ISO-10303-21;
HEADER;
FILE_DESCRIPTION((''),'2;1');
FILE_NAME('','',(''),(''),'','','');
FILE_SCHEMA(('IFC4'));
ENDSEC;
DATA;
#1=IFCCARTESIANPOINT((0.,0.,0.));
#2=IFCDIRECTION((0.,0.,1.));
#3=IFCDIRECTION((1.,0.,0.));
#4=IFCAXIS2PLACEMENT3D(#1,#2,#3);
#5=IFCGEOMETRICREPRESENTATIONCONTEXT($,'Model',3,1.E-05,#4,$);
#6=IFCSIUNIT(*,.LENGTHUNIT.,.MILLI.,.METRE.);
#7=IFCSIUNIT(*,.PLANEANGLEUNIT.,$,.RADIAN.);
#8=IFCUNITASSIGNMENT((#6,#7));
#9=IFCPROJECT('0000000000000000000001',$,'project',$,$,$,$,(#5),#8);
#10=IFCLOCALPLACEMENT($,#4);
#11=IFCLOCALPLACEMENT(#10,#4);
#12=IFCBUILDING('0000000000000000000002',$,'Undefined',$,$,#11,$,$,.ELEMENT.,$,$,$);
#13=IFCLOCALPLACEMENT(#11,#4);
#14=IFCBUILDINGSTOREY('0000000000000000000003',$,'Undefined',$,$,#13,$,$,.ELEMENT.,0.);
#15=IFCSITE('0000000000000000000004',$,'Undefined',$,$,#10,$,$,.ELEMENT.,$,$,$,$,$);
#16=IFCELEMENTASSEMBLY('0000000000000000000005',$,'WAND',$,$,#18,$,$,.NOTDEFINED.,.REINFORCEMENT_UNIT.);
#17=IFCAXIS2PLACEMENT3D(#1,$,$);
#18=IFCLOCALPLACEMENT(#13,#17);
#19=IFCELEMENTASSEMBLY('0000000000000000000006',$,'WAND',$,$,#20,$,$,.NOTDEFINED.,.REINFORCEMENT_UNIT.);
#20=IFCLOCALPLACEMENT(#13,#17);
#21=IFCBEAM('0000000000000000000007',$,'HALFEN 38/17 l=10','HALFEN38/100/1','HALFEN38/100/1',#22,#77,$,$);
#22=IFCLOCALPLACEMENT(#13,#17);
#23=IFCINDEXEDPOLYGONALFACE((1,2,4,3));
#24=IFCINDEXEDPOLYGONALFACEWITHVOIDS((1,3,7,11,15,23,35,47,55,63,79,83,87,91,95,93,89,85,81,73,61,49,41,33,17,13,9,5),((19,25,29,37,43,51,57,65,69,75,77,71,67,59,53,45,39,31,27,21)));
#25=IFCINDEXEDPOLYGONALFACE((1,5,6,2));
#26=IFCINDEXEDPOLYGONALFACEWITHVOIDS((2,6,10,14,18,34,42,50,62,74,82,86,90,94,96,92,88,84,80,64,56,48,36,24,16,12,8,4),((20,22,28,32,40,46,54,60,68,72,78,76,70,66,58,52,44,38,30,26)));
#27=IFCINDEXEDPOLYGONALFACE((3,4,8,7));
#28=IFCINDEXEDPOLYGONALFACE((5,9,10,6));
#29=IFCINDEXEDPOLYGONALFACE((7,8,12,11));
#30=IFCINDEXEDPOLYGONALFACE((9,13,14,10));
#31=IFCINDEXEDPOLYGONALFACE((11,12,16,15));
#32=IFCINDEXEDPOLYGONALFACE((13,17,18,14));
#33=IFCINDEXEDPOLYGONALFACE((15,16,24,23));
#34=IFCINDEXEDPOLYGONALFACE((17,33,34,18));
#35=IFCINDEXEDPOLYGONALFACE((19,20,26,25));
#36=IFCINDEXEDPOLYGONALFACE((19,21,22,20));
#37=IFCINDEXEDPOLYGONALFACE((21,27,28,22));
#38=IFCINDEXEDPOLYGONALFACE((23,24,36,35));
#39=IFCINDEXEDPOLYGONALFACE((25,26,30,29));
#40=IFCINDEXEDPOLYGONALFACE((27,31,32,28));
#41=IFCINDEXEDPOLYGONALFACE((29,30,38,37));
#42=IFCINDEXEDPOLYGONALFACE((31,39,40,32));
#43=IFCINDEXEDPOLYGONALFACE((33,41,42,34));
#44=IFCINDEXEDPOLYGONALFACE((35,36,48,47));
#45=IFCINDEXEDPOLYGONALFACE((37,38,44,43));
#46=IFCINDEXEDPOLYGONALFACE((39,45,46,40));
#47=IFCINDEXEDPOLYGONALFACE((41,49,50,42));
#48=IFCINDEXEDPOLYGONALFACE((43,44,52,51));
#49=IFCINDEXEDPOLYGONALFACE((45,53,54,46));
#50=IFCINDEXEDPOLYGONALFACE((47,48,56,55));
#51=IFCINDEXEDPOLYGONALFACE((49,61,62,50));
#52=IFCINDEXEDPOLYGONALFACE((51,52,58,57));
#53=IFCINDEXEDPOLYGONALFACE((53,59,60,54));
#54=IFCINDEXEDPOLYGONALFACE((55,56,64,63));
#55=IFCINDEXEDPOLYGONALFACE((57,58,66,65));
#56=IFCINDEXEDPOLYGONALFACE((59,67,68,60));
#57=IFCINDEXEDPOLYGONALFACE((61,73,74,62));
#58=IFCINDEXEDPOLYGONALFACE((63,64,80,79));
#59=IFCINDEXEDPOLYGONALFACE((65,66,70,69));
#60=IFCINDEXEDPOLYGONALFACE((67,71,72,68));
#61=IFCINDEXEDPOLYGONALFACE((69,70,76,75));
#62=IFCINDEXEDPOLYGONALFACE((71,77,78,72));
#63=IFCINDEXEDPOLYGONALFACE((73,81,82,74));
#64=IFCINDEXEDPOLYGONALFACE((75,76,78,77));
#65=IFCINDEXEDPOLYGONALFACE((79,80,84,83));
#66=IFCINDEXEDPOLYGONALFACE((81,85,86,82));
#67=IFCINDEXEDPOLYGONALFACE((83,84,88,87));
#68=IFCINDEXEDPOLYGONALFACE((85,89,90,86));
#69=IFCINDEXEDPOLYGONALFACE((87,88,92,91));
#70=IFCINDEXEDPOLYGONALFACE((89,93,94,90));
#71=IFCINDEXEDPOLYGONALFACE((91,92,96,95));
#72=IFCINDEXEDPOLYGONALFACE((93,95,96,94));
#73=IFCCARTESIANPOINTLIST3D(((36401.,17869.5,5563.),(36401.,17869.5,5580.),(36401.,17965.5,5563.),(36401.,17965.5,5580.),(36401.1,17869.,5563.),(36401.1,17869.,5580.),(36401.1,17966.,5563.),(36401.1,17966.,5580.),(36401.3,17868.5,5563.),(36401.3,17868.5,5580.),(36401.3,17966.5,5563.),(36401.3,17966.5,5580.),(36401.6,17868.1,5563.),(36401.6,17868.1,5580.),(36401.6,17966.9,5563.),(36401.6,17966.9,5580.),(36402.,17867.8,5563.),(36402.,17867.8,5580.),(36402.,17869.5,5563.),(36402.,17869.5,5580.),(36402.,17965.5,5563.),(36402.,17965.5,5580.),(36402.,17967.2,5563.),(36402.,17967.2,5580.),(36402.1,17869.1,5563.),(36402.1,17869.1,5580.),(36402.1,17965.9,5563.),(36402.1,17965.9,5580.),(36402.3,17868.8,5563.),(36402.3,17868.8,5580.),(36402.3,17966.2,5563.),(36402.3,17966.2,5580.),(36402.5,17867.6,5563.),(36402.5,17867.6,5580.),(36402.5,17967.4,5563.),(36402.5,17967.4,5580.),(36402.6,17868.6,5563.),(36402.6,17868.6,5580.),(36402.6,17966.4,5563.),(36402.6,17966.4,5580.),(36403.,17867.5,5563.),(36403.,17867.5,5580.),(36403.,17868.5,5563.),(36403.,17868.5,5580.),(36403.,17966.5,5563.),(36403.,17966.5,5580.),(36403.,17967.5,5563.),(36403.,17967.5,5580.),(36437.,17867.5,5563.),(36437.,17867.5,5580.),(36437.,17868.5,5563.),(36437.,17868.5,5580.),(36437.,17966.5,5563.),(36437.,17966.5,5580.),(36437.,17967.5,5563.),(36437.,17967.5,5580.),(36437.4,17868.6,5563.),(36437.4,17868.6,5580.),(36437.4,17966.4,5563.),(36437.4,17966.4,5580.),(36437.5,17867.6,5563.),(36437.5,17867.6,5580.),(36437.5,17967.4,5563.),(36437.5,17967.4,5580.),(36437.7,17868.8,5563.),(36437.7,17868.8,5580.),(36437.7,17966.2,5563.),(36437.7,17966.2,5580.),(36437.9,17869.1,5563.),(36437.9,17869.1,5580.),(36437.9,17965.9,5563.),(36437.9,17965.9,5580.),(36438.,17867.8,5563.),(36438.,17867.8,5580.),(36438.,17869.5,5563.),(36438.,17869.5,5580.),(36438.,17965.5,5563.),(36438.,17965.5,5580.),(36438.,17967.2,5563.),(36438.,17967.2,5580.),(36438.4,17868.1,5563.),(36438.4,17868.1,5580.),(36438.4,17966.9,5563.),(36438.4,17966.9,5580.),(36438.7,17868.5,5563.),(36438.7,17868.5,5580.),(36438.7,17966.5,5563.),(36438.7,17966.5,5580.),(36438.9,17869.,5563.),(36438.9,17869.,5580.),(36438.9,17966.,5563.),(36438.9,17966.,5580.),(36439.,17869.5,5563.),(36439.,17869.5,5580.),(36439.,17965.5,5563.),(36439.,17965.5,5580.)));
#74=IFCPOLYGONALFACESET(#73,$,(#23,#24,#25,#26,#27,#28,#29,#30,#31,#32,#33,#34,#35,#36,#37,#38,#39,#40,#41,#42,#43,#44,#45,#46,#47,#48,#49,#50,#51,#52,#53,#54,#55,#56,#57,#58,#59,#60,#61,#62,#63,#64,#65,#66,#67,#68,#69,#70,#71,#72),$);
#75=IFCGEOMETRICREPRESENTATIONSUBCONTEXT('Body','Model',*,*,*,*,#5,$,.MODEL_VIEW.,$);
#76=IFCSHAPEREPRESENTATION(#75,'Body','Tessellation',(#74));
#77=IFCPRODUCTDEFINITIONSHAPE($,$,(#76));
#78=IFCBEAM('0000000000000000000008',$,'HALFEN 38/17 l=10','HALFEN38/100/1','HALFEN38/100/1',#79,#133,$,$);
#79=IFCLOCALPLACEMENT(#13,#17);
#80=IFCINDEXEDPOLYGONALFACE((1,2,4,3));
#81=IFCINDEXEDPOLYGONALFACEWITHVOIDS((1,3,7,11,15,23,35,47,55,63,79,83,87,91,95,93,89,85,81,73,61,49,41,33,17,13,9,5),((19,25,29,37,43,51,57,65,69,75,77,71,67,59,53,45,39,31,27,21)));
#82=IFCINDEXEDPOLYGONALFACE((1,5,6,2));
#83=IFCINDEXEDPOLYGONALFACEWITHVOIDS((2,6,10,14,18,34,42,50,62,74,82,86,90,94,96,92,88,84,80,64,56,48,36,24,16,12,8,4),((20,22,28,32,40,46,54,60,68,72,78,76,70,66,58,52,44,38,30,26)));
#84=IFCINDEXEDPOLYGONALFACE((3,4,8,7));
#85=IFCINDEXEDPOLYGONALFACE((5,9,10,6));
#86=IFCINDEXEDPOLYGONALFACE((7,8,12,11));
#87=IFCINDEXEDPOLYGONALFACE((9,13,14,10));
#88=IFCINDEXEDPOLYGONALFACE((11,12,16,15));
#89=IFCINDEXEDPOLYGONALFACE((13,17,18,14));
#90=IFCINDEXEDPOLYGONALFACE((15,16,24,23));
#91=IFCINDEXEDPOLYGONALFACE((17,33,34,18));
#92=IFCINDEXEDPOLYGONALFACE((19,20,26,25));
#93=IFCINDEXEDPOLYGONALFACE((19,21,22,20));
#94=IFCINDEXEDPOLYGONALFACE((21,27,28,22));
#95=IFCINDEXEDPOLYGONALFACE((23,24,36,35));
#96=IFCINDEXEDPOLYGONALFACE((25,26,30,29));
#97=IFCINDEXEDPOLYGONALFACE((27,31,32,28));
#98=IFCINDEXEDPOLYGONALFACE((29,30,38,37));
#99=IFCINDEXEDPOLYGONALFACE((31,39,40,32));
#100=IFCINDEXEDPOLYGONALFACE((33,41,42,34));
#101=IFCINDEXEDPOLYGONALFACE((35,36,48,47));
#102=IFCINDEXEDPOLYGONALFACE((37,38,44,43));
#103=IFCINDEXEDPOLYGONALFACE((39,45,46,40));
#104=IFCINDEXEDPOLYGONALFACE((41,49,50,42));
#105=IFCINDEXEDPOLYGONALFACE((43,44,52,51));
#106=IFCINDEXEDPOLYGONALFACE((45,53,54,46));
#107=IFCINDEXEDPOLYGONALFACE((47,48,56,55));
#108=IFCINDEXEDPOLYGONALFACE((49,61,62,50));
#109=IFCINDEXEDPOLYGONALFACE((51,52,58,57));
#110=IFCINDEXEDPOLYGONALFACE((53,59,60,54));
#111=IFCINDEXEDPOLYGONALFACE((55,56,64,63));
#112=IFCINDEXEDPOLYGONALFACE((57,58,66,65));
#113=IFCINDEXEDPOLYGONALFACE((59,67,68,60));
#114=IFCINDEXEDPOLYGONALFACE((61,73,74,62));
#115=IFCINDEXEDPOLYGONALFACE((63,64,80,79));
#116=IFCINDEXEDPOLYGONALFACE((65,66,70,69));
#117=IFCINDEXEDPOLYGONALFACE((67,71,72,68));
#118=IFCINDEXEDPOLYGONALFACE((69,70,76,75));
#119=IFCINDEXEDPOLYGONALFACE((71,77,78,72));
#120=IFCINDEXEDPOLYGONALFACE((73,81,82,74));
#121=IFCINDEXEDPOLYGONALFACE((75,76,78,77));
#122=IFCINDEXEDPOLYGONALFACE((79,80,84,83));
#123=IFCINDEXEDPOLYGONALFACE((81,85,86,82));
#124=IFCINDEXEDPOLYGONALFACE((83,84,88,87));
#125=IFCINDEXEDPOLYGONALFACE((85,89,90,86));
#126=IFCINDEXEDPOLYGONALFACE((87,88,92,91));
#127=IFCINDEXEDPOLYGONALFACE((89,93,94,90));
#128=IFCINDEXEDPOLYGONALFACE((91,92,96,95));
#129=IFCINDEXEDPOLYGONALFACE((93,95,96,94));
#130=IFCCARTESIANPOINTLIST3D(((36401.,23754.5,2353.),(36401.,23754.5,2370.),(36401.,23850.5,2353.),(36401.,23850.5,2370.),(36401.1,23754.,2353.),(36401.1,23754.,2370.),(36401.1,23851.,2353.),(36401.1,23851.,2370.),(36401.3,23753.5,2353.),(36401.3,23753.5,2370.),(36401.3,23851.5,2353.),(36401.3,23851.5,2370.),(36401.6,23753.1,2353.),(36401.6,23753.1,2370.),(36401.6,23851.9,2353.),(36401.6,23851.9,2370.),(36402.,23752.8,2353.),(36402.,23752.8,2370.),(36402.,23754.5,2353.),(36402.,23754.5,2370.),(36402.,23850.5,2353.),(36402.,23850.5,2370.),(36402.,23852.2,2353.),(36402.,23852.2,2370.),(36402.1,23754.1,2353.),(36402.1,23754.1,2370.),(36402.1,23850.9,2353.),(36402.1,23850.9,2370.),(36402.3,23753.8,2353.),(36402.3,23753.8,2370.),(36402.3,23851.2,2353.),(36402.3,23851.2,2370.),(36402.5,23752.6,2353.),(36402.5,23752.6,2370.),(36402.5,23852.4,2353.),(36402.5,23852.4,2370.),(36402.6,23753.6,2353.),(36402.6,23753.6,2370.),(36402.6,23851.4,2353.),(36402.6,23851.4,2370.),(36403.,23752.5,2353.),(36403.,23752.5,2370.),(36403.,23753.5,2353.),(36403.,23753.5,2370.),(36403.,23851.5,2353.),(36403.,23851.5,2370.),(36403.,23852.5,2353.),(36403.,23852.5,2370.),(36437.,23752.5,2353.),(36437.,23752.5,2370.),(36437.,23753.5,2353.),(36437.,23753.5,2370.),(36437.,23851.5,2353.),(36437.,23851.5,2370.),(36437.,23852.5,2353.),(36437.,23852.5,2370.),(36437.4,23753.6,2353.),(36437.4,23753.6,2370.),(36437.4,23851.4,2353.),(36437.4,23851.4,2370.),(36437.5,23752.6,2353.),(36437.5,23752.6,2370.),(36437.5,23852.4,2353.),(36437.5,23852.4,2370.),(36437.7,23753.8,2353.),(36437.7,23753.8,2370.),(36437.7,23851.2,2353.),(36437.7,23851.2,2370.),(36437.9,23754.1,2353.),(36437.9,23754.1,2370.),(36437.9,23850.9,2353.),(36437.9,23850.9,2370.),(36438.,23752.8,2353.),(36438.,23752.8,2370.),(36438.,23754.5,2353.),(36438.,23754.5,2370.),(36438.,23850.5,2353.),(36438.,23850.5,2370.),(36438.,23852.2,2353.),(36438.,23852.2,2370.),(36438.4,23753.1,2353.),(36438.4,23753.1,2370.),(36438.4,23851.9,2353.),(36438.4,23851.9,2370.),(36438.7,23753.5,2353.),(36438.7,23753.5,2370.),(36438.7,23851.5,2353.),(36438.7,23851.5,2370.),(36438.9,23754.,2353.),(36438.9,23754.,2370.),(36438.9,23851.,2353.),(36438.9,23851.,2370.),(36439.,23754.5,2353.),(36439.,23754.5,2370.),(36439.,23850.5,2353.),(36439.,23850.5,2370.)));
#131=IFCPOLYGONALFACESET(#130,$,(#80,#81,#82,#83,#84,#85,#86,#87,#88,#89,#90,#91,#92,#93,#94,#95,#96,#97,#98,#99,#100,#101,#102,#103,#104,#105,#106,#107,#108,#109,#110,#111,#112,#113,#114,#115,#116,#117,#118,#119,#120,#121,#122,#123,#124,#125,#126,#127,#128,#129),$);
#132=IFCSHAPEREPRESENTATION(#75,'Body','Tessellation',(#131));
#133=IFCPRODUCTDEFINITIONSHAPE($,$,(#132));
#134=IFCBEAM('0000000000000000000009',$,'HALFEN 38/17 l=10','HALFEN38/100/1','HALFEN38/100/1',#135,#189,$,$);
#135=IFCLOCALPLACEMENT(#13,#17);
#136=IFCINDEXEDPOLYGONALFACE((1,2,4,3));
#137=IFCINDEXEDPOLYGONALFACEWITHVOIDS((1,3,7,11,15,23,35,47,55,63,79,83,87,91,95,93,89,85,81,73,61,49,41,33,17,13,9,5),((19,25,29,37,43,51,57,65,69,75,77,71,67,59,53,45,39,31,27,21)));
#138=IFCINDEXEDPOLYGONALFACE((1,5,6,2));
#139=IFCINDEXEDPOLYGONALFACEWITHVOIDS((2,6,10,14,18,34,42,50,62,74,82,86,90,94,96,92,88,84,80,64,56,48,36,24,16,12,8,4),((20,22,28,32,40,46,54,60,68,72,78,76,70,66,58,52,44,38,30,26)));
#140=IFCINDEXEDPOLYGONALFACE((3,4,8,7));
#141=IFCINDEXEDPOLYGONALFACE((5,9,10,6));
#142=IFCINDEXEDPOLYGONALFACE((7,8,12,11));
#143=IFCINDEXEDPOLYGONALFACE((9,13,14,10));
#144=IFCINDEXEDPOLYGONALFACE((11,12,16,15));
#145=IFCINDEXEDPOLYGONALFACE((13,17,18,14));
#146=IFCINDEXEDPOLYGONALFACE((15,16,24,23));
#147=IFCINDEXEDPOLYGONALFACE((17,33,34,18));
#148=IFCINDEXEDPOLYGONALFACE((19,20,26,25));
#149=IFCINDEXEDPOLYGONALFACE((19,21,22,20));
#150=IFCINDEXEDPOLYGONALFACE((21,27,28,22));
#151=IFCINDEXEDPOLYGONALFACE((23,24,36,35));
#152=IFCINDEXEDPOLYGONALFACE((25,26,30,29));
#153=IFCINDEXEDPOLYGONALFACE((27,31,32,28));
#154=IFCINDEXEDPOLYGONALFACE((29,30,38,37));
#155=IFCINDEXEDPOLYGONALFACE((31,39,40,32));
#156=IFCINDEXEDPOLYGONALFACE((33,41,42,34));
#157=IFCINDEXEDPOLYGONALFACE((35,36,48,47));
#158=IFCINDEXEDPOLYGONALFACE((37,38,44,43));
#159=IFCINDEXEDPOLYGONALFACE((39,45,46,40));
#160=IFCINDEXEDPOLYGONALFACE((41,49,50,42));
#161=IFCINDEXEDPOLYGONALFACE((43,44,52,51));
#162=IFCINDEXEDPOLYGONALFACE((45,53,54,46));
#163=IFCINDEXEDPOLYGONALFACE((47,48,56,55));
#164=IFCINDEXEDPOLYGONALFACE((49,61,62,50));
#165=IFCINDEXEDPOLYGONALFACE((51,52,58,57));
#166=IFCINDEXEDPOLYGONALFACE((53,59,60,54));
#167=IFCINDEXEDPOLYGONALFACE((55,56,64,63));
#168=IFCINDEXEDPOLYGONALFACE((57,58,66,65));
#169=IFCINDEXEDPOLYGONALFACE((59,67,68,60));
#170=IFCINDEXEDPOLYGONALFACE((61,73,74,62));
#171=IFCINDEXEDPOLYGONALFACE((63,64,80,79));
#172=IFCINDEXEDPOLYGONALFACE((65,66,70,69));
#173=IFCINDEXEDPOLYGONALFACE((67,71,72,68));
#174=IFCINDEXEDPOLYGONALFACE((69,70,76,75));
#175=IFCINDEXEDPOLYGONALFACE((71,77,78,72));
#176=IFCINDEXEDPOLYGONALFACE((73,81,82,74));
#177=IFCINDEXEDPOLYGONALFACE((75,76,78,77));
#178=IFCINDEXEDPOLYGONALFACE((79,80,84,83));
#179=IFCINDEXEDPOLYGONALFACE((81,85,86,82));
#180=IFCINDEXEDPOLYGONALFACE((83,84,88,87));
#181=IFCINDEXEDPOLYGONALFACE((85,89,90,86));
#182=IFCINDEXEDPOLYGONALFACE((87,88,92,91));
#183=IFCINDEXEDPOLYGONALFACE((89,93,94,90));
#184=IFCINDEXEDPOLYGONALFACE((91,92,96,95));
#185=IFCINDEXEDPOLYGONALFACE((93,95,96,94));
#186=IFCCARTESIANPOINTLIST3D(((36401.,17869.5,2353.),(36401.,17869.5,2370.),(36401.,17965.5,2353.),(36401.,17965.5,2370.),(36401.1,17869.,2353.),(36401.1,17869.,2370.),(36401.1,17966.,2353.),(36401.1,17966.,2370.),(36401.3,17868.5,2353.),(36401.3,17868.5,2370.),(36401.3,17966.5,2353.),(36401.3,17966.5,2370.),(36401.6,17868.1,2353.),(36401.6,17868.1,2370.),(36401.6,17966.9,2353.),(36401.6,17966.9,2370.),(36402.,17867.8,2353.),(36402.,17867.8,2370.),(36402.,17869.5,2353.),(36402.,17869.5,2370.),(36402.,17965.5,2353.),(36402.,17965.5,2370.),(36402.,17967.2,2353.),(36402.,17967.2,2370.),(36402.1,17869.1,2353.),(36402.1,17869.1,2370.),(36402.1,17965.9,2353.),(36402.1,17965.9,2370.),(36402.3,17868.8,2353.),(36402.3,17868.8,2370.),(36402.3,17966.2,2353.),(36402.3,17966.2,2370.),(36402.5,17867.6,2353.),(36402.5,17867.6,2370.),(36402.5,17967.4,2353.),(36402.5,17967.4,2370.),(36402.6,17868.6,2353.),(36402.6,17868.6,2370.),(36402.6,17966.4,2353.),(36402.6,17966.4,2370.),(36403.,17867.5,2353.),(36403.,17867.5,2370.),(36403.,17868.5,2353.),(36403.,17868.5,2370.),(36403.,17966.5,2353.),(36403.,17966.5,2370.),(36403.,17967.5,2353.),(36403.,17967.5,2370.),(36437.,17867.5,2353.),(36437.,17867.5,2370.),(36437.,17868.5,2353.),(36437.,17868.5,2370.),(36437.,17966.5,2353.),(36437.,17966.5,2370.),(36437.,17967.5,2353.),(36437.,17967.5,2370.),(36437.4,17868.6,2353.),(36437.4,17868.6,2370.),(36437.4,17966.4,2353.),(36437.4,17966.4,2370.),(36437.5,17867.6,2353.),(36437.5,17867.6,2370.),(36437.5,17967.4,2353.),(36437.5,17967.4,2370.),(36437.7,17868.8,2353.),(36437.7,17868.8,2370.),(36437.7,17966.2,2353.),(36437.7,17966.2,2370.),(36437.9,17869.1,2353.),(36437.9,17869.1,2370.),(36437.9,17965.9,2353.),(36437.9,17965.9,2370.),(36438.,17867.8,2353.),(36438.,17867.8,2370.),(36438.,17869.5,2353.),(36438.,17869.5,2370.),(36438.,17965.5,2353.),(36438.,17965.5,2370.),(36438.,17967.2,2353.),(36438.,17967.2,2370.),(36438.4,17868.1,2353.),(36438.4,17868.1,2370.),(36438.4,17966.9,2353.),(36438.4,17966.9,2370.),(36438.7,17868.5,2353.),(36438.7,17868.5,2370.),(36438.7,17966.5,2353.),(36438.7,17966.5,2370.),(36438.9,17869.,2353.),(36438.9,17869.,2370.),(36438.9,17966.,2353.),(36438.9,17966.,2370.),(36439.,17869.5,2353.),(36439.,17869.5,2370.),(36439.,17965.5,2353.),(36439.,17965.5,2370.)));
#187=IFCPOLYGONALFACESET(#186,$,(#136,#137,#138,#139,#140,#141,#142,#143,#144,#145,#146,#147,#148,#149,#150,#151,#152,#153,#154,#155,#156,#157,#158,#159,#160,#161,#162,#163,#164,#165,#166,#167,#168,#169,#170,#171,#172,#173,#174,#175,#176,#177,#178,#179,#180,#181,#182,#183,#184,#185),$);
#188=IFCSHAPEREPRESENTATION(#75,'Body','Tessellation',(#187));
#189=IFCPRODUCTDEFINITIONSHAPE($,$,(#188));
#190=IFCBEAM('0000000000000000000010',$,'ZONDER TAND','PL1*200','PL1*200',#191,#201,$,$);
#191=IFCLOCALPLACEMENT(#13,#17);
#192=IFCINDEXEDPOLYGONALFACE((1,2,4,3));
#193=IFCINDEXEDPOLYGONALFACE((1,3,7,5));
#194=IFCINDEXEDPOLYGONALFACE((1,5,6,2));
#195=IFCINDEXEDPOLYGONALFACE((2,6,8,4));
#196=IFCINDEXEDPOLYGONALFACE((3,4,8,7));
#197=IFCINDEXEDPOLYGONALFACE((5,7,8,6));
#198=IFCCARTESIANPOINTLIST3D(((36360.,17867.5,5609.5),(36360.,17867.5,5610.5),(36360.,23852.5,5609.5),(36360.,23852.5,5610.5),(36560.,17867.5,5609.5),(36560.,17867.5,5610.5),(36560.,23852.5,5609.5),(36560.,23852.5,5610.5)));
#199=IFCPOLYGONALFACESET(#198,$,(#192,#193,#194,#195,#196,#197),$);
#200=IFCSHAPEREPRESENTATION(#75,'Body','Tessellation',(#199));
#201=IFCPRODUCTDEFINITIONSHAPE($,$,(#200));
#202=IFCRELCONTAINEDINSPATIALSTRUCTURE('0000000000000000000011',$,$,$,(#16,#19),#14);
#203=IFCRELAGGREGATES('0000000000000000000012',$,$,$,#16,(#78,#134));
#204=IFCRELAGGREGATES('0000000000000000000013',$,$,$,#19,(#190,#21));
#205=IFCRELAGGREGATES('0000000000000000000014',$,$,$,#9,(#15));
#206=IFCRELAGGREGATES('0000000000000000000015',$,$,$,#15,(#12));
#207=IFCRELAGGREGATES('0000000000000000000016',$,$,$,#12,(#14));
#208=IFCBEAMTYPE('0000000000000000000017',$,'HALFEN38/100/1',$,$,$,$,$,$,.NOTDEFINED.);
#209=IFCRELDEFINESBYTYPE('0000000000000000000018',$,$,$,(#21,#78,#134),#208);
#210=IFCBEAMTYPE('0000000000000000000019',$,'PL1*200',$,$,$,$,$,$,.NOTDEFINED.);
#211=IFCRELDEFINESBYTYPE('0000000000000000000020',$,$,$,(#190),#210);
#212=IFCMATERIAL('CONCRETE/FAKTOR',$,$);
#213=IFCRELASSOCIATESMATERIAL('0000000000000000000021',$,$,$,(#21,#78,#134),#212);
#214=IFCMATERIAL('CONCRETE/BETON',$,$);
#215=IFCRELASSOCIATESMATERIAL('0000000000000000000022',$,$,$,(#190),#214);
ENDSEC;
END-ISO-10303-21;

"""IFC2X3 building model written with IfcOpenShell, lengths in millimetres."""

from ifc_helpers import new_model, si_unit, frame, frame_2d, origin_with_axes, place, context, subcontext, project, spatial, rectangle, hollow_rectangle, extrude, material, type_object, element, aggregate, save


model = new_model("IFC2X3")

# Units and contexts
model_context = context("Model", 3, precision=1e-05, world=origin_with_axes())
body_context = subcontext(model_context, "Body", "Model", "MODEL_VIEW")
ifc_project = project(units=[si_unit("LENGTHUNIT", "METRE", prefix="MILLI"), si_unit("PLANEANGLEUNIT", "RADIAN")], contexts=[model_context])

# Site, building, storey
site_placement = place(None, origin_with_axes())
site = spatial("IfcSite", under=ifc_project, at=site_placement, Name="Undefined", CompositionType="ELEMENT")
building_placement = place(site_placement, origin_with_axes())
building = spatial("IfcBuilding", under=site, at=building_placement, Name="Undefined", CompositionType="ELEMENT")
storey_placement = place(building_placement, origin_with_axes())
storey = spatial("IfcBuildingStorey", under=building, at=storey_placement, Name="Undefined", CompositionType="ELEMENT", Elevation=0.0)

# Element assembly
ifc_material_1 = material(Name="CONCRETE/FAKTOR")
assembly_1_placement = place(storey_placement, origin_with_axes())
assembly_1 = element("IfcElementAssembly", 1, at=assembly_1_placement, inside=storey, Name="WAND", AssemblyPlace="NOTDEFINED", PredefinedType="REINFORCEMENT_UNIT")

# Shared definitions
ifc_material_2 = material(Name="CONCRETE/BETON")

# Element assembly, beam
assembly_2_placement = place(storey_placement, origin_with_axes())
assembly_2 = element("IfcElementAssembly", 2, at=assembly_2_placement, inside=storey, Name="WAND", AssemblyPlace="NOTDEFINED", PredefinedType="REINFORCEMENT_UNIT")
beam_type_1 = type_object("IfcBeamType", Name="HALFEN38/100/1", PredefinedType="NOTDEFINED")
beam_1_placement = place(assembly_2_placement, frame((36420.0, 17917.5, 5580.0), z_axis=(1.0, 0.0, 0.0), x_axis=(0.0, 0.0, -1.0)))
beam_1 = element("IfcBeam", 3, at=beam_1_placement, type_object=beam_type_1, material=ifc_material_1, Name="HALFEN 38/17 l=10", Description="HALFEN38/100/1", ObjectType="HALFEN38/100/1", context=body_context, shape_type="SweptSolid", body=[
    extrude(hollow_rectangle(XDim=100.0, YDim=38.0, WallThickness=1.0, InnerFilletRadius=1.0, OuterFilletRadius=2.0, at=frame_2d((0.0, 0.0), x_axis=(1.0, 0.0))), frame((17.0, 0.0, 0.0), z_axis=(-1.0, 0.0, 0.0), x_axis=(0.0, -1.0, 0.0)), (0.0, 0.0, 1.0), 17.0),
])

# Beams
beam_2_placement = place(assembly_1_placement, frame((36420.0, 23802.5, 2370.0), z_axis=(1.0, 0.0, 0.0), x_axis=(0.0, 0.0, -1.0)))
beam_2 = element("IfcBeam", 4, at=beam_2_placement, type_object=beam_type_1, material=ifc_material_1, Name="HALFEN 38/17 l=10", Description="HALFEN38/100/1", ObjectType="HALFEN38/100/1", context=body_context, shape_type="SweptSolid", body=[
    extrude(hollow_rectangle(XDim=100.0, YDim=38.0, WallThickness=1.0, InnerFilletRadius=1.0, OuterFilletRadius=2.0, at=frame_2d((0.0, 0.0), x_axis=(1.0, 0.0))), frame((17.0, 0.0, 0.0), z_axis=(-1.0, 0.0, 0.0), x_axis=(0.0, -1.0, 0.0)), (0.0, 0.0, 1.0), 17.0),
])
beam_3_placement = place(assembly_1_placement, frame((36420.0, 17917.5, 2370.0), z_axis=(1.0, 0.0, 0.0), x_axis=(0.0, 0.0, -1.0)))
beam_3 = element("IfcBeam", 5, at=beam_3_placement, type_object=beam_type_1, material=ifc_material_1, Name="HALFEN 38/17 l=10", Description="HALFEN38/100/1", ObjectType="HALFEN38/100/1", context=body_context, shape_type="SweptSolid", body=[
    extrude(hollow_rectangle(XDim=100.0, YDim=38.0, WallThickness=1.0, InnerFilletRadius=1.0, OuterFilletRadius=2.0, at=frame_2d((0.0, 0.0), x_axis=(1.0, 0.0))), frame((17.0, 0.0, 0.0), z_axis=(-1.0, 0.0, 0.0), x_axis=(0.0, -1.0, 0.0)), (0.0, 0.0, 1.0), 17.0),
])
aggregate(assembly_1, [beam_2, beam_3])
beam_type_2 = type_object("IfcBeamType", Name="PL1*200", PredefinedType="NOTDEFINED")
beam_4_placement = place(assembly_2_placement, frame((36460.0, 17867.5, 5610.0), z_axis=(1.0, 0.0, 0.0), x_axis=(0.0, 1.0, 0.0)))
beam_4 = element("IfcBeam", 6, at=beam_4_placement, type_object=beam_type_2, material=ifc_material_2, Name="ZONDER TAND", Description="PL1*200", ObjectType="PL1*200", context=body_context, shape_type="SweptSolid", body=[
    extrude(rectangle(XDim=1.0, YDim=200.0, at=frame_2d((0.0, 0.0), x_axis=(1.0, 0.0))), frame((5985.0, 0.0, 0.0), z_axis=(-1.0, 0.0, 0.0), x_axis=(0.0, -1.0, 0.0)), (0.0, 0.0, 1.0), 5985.0),
])
aggregate(assembly_2, [beam_4, beam_1])

save(model, "model.ifc")
